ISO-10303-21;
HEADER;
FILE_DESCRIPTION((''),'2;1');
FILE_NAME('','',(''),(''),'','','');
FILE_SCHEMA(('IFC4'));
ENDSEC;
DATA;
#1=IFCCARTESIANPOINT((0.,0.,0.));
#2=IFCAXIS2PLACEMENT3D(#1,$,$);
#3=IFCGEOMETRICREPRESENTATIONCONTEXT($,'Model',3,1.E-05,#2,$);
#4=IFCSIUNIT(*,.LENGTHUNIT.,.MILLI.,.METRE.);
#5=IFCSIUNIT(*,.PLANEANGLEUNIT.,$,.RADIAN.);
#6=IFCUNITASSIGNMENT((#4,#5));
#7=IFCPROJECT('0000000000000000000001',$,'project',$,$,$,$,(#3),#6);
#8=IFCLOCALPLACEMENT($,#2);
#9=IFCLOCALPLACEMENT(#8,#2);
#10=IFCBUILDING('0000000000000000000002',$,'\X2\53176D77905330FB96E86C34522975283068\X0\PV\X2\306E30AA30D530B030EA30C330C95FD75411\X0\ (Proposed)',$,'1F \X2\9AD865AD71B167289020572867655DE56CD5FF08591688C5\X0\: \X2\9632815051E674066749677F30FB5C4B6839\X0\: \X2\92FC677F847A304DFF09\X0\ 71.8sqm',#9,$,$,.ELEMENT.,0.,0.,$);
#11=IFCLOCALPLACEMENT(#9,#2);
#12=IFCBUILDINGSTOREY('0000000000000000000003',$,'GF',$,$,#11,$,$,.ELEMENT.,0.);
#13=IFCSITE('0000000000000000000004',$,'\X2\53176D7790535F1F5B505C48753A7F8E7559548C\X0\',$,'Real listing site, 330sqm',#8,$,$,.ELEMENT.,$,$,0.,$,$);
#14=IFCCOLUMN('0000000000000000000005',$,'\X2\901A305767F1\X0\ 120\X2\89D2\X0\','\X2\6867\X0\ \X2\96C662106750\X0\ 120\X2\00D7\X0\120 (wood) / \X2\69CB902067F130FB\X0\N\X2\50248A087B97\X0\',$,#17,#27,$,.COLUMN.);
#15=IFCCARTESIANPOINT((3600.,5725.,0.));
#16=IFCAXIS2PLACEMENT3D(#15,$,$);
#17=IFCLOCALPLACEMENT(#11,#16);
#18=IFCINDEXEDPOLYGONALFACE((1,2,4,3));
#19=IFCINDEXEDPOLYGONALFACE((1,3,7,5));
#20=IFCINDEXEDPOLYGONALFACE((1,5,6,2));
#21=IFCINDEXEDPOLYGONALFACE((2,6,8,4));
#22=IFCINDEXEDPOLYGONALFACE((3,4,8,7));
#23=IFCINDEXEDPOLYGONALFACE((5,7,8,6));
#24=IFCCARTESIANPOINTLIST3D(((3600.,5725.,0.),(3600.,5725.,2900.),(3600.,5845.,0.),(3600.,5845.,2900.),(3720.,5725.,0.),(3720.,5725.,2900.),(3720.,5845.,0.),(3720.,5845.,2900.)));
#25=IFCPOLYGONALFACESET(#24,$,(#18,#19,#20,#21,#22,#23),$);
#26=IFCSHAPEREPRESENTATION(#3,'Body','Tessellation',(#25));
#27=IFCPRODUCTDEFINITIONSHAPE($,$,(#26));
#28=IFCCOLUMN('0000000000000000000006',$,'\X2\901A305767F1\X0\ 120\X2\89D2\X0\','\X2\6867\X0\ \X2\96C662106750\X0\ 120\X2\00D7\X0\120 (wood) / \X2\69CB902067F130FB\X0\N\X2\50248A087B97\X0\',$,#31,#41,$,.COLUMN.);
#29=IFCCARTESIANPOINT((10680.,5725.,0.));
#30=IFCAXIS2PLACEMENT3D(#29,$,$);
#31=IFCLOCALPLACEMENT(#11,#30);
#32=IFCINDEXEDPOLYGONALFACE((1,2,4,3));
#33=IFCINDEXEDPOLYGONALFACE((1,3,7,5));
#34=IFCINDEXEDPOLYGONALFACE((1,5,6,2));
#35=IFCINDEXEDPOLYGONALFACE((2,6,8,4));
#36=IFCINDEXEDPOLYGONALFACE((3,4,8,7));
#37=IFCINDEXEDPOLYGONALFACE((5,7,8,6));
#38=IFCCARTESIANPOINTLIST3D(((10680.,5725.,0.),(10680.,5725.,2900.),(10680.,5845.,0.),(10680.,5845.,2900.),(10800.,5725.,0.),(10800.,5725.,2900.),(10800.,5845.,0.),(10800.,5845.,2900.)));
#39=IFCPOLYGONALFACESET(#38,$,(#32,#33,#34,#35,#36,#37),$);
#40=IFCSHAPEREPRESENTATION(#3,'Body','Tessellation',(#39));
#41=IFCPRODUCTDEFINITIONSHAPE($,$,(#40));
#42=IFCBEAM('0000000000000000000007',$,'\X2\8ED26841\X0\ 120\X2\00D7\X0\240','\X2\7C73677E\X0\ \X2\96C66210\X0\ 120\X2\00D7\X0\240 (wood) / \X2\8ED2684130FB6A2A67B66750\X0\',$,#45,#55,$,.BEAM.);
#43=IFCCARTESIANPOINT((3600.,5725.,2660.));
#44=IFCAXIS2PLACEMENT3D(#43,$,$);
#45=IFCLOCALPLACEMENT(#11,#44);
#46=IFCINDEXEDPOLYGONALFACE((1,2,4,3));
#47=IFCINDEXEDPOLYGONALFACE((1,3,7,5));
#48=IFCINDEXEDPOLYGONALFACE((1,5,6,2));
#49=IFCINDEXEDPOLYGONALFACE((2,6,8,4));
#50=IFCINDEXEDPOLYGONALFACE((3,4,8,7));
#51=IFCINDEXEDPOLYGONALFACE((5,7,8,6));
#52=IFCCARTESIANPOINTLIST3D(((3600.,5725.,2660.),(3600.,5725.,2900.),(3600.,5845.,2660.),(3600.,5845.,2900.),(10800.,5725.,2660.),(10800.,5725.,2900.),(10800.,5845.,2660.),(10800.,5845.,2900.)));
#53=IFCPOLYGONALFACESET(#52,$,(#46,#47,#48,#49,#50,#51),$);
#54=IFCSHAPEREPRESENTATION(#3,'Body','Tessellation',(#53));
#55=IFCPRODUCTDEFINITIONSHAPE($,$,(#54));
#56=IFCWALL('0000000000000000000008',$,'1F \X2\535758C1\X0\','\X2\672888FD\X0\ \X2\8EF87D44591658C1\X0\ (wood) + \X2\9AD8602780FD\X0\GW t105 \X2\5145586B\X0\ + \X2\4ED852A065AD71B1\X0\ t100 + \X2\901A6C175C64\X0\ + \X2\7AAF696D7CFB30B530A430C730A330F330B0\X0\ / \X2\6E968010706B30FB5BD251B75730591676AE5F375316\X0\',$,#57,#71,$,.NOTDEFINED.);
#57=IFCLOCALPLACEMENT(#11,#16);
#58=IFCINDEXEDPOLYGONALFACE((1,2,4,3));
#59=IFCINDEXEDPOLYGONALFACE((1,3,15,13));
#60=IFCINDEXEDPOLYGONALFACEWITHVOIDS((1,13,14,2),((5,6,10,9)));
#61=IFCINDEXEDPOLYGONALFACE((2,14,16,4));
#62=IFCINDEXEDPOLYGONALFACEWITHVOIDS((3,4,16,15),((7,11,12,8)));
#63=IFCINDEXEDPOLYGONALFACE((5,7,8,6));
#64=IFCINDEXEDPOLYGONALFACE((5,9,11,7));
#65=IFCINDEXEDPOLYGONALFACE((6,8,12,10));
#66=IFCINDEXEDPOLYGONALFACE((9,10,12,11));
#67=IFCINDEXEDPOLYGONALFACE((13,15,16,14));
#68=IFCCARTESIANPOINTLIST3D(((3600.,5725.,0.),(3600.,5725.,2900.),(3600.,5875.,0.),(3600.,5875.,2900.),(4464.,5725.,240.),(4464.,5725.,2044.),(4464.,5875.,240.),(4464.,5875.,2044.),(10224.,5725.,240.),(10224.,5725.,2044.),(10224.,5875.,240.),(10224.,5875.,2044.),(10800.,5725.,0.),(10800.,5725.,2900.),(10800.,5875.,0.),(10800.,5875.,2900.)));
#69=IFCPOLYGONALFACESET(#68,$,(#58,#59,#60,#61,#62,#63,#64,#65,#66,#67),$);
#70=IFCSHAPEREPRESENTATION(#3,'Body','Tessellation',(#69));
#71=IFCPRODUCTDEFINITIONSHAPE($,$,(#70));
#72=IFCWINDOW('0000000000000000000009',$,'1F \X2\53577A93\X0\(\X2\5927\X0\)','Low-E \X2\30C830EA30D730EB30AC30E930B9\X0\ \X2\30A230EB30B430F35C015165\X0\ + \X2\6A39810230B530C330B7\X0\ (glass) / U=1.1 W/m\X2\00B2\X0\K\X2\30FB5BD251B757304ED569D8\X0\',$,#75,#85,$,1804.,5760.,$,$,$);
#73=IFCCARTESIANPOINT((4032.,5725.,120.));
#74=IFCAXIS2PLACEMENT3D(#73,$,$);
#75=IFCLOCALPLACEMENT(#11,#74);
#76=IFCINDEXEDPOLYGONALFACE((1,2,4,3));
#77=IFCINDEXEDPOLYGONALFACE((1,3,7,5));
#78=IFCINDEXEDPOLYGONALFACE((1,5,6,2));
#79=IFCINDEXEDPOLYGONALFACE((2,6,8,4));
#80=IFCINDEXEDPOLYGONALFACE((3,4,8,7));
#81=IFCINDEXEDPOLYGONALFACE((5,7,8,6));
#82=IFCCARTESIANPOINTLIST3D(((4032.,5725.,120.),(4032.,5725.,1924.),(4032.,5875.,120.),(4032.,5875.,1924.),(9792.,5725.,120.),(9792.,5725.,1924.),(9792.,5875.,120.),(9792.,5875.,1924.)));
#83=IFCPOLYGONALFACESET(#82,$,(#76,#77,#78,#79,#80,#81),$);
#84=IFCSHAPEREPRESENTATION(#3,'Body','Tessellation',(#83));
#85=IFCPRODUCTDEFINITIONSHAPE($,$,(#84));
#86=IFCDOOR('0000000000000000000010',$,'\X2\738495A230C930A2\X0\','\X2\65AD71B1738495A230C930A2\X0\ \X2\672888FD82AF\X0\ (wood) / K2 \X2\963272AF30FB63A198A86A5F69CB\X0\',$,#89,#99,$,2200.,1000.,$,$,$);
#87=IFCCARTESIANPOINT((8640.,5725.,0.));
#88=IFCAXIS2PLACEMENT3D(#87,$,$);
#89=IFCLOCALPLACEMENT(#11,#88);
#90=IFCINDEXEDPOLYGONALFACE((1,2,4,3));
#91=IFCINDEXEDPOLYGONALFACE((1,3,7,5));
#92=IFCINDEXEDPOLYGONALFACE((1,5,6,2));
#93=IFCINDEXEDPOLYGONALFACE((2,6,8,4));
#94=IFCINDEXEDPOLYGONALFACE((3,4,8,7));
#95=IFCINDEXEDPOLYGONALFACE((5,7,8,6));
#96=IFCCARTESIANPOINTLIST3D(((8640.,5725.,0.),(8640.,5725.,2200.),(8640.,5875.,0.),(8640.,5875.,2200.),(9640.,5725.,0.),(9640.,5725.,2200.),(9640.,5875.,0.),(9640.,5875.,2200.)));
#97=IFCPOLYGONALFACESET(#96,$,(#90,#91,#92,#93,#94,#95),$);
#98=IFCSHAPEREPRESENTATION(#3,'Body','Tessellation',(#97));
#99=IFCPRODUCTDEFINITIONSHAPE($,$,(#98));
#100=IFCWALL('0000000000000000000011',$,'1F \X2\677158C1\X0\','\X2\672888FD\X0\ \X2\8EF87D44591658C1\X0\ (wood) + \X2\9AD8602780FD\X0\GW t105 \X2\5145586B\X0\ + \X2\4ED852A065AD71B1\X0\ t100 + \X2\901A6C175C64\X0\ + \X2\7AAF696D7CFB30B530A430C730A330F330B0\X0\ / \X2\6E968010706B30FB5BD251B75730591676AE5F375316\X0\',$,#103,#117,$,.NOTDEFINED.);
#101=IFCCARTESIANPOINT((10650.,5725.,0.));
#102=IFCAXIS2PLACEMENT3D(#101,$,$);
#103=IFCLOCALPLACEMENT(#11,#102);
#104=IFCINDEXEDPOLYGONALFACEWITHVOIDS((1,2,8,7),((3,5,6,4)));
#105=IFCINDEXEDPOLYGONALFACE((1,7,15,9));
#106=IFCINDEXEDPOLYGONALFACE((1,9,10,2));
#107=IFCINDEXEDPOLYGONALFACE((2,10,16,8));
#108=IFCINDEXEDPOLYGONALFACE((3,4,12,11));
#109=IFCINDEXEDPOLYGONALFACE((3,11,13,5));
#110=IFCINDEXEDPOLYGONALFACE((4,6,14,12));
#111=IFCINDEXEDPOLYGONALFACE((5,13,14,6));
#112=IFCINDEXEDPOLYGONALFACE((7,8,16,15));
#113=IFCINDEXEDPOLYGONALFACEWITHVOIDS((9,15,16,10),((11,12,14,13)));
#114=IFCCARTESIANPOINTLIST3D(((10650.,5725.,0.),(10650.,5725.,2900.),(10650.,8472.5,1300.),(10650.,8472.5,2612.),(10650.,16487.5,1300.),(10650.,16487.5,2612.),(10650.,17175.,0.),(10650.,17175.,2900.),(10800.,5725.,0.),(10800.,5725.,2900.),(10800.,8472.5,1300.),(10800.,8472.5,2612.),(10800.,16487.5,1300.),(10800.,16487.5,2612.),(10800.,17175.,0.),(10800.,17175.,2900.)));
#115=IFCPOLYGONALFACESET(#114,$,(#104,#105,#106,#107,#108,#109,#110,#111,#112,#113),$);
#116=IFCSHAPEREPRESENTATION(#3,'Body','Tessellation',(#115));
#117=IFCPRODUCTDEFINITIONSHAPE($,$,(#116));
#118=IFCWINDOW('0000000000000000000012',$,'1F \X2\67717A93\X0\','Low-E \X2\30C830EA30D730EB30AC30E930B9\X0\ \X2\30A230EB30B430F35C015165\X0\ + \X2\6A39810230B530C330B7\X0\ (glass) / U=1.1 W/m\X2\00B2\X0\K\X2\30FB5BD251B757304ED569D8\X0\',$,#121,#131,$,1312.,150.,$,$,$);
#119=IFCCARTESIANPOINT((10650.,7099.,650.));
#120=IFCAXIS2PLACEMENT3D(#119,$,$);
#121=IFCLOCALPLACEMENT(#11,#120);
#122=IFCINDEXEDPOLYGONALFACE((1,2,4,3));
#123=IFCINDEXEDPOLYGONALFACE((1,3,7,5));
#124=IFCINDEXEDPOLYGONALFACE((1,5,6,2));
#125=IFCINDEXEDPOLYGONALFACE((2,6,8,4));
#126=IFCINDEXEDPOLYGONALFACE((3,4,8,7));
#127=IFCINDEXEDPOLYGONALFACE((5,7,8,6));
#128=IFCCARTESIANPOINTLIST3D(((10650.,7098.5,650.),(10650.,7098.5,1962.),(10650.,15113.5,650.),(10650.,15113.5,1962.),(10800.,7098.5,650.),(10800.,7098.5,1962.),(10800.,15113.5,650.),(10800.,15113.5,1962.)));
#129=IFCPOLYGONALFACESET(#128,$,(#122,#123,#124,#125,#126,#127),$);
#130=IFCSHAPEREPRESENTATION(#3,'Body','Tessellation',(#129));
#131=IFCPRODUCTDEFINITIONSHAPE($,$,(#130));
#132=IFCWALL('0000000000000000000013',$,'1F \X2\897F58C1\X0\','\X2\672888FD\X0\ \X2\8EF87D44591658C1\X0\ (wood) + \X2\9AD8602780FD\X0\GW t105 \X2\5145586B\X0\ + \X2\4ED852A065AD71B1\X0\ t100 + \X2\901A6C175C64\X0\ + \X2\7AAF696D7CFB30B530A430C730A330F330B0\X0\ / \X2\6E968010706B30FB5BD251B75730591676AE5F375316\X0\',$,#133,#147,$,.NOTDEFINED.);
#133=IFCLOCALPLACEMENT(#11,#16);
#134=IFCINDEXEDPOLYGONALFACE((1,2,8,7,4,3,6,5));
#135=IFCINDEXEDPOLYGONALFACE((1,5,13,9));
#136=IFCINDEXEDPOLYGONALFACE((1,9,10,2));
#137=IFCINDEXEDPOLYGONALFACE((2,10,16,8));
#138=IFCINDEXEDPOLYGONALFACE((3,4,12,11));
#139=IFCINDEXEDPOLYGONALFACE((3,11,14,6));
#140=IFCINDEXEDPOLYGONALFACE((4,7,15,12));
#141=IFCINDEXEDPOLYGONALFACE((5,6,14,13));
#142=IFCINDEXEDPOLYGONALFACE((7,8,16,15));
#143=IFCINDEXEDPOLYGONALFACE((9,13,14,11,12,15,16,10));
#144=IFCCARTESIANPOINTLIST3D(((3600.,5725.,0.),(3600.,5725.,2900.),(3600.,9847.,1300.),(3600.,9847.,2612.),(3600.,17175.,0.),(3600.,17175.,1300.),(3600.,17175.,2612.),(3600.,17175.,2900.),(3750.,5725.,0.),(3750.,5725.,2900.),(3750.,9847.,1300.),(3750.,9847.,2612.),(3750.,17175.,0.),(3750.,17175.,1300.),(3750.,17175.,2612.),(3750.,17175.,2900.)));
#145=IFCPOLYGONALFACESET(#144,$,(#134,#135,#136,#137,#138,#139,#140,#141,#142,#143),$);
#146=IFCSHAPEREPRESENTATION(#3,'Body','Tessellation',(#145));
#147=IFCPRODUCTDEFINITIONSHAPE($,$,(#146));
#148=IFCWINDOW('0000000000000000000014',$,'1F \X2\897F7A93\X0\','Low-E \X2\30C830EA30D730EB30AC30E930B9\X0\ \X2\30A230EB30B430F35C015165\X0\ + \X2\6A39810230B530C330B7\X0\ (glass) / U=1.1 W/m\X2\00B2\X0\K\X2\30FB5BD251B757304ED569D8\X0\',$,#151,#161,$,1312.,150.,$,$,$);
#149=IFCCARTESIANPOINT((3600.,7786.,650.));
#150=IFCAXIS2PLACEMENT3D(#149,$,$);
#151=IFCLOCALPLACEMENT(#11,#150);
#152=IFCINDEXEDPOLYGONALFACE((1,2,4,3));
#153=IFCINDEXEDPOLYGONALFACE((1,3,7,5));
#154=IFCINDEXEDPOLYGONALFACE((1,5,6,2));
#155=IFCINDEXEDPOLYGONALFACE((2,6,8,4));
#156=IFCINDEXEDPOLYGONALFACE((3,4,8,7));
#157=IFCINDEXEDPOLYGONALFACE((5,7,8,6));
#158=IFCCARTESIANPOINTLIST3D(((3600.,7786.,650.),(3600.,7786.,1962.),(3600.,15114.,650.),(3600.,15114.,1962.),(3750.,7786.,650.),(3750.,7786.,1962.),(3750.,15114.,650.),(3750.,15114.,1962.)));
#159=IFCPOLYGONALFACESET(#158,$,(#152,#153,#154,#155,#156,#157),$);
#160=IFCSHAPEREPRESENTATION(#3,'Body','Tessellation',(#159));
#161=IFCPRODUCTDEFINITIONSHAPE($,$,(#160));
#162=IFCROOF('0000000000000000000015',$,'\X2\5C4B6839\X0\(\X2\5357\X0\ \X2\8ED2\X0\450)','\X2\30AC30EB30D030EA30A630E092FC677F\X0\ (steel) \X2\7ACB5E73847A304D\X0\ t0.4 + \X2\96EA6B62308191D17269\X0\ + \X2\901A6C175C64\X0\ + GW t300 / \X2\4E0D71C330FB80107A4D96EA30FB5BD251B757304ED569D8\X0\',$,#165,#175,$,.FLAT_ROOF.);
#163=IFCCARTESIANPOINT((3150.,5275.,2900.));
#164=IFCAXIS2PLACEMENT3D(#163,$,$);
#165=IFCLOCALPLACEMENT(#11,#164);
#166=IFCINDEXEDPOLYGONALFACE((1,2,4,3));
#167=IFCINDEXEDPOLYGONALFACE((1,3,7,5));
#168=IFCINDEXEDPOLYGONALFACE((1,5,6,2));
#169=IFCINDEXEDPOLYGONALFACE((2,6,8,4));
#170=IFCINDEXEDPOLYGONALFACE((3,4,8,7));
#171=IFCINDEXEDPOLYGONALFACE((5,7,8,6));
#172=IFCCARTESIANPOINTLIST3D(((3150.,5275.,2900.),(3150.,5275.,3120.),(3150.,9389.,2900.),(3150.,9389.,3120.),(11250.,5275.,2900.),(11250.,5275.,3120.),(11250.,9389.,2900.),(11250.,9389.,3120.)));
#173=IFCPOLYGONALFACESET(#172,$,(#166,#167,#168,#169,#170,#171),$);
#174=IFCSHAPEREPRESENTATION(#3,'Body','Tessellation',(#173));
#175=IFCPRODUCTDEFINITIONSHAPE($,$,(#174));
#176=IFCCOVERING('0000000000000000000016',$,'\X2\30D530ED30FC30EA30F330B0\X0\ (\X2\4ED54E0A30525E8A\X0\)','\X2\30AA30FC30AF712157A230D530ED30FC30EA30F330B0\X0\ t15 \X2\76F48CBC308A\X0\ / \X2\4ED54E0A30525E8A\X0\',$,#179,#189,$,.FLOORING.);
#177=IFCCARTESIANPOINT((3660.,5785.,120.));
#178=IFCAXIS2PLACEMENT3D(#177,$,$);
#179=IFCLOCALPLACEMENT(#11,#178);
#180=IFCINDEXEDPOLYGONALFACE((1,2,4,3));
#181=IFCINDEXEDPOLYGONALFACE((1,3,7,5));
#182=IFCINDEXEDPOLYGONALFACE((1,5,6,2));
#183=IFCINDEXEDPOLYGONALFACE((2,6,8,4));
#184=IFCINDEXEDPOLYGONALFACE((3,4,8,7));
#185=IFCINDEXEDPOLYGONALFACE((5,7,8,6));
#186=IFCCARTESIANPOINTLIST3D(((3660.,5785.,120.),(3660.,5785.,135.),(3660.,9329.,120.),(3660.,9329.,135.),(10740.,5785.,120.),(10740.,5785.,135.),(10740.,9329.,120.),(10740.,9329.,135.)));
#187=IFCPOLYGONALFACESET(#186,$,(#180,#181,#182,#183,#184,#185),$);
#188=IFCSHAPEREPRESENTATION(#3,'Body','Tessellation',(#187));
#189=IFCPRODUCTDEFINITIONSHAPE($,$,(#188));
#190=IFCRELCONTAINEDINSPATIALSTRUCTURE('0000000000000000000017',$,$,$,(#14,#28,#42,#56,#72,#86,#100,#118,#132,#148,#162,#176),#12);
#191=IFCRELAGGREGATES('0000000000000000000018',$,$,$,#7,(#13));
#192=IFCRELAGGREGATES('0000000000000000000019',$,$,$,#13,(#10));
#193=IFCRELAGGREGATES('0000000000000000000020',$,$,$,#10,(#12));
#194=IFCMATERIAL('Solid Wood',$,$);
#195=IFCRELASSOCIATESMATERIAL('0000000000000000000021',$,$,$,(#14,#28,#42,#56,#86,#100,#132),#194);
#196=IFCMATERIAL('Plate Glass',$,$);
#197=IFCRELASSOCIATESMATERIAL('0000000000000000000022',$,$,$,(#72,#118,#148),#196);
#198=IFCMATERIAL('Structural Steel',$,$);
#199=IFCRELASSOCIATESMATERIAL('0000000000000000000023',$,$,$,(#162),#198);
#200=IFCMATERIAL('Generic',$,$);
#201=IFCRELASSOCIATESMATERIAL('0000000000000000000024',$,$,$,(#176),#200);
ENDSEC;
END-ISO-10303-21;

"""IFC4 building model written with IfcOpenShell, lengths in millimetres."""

from ifc_helpers import new_model, si_unit, frame, frame_2d, origin, place, context, project, spatial, rectangle, extrude, material, element, fill, save


model = new_model("IFC4")

# Units and contexts
model_context = context("Model", 3, precision=1e-05, world=origin())
ifc_project = project(units=[si_unit("LENGTHUNIT", "METRE", prefix="MILLI"), si_unit("PLANEANGLEUNIT", "RADIAN")], contexts=[model_context])

# Site, building, storey
site_placement = place(None, origin())
site = spatial("IfcSite", under=ifc_project, at=site_placement, Name="北海道弟子屈町美留和", ObjectType="Real listing site, 330sqm", CompositionType="ELEMENT", RefElevation=0.0)
building_placement = place(site_placement, origin())
building = spatial("IfcBuilding", under=site, at=building_placement, Name="北海道・雨水利用とPVのオフグリッド志向 (Proposed)", ObjectType="1F 高断熱木造在来工法（外装: 防腐処理杉板・屋根: 鋼板葺き） 71.8sqm", CompositionType="ELEMENT", ElevationOfRefHeight=0.0, ElevationOfTerrain=0.0)
storey_placement = place(building_placement, origin())
storey = spatial("IfcBuildingStorey", under=building, at=storey_placement, Name="GF", CompositionType="ELEMENT", Elevation=0.0)

# Columns
ifc_material_1 = material(Name="Solid Wood")
column_1_placement = place(storey_placement, frame((3600.0, 5725.0, 0.0)))
element("IfcColumn", 1, at=column_1_placement, inside=storey, material=ifc_material_1, Name="通し柱 120角", Description="桧 集成材 120×120 (wood) / 構造柱・N値計算", PredefinedType="COLUMN", context=model_context, shape_type="SweptSolid", body=[
    extrude(rectangle(XDim=120.0, YDim=120.0, at=frame_2d((60.0, 60.0))), frame((3600.0, 5725.0, 0.0)), (0.0, 0.0, 1.0), 2900.0),
])
column_2_placement = place(storey_placement, frame((10680.0, 5725.0, 0.0)))
element("IfcColumn", 2, at=column_2_placement, inside=storey, material=ifc_material_1, Name="通し柱 120角", Description="桧 集成材 120×120 (wood) / 構造柱・N値計算", PredefinedType="COLUMN", context=model_context, shape_type="SweptSolid", body=[
    extrude(rectangle(XDim=120.0, YDim=120.0, at=frame_2d((60.0, 60.0))), frame((10680.0, 5725.0, 0.0)), (0.0, 0.0, 1.0), 2900.0),
])

# Beam
beam_1_placement = place(storey_placement, frame((3600.0, 5725.0, 2660.0)))
element("IfcBeam", 3, at=beam_1_placement, inside=storey, material=ifc_material_1, Name="軒桁 120×240", Description="米松 集成 120×240 (wood) / 軒桁・横架材", PredefinedType="BEAM", context=model_context, shape_type="SweptSolid", body=[
    extrude(rectangle(XDim=7200.0, YDim=120.0, at=frame_2d((3600.0, 60.0))), frame((3600.0, 5725.0, 2660.0)), (0.0, 0.0, 1.0), 240.0),
])

# Wall, openings, window, door
wall_1_placement = place(storey_placement, frame((3600.0, 5725.0, 0.0)))
wall_1 = element("IfcWall", 4, at=wall_1_placement, inside=storey, material=ifc_material_1, Name="1F 南壁", Description="木製 軸組外壁 (wood) + 高性能GW t105 充填 + 付加断熱 t100 + 通気層 + 窯業系サイディング / 準耐火・寒冷地外皮強化", PredefinedType="NOTDEFINED", context=model_context, shape_type="SweptSolid", body=[
    extrude(rectangle(XDim=7200.0, YDim=150.0, at=frame_2d((3600.0, 75.0))), frame((3600.0, 5725.0, 0.0)), (0.0, 0.0, 1.0), 2900.0),
])
opening_1_placement = place(storey_placement, frame((4032.0, 5725.0, 120.0)))
opening_1 = element("IfcOpeningElement", 5, at=opening_1_placement, cuts=wall_1, PredefinedType="NOTDEFINED", context=model_context, shape_type="SweptSolid", body=[
    extrude(rectangle(XDim=5760.0, YDim=150.0, at=frame_2d((2880.0, 75.0))), frame((4032.0, 5725.0, 120.0)), (0.0, 0.0, 1.0), 1804.0),
])
opening_2_placement = place(storey_placement, frame((8640.0, 5725.0, 0.0)))
opening_2 = element("IfcOpeningElement", 6, at=opening_2_placement, cuts=wall_1, PredefinedType="NOTDEFINED", context=model_context, shape_type="SweptSolid", body=[
    extrude(rectangle(XDim=1000.0, YDim=150.0, at=frame_2d((500.0, 75.0))), frame((8640.0, 5725.0, 0.0)), (0.0, 0.0, 1.0), 2200.0),
])
ifc_material_2 = material(Name="Plate Glass")
window_1_placement = place(storey_placement, frame((4032.0, 5725.0, 120.0)))
window_1 = element("IfcWindow", 7, at=window_1_placement, inside=storey, material=ifc_material_2, Name="1F 南窓(大)", Description="Low-E トリプルガラス アルゴン封入 + 樹脂サッシ (glass) / U=1.1 W/m²K・寒冷地仕様", OverallHeight=1804.0, OverallWidth=5760.0, context=model_context, shape_type="SweptSolid", body=[
    extrude(rectangle(XDim=5760.0, YDim=150.0, at=frame_2d((2880.0, 75.0))), frame((4032.0, 5725.0, 120.0)), (0.0, 0.0, 1.0), 1804.0),
])
fill(opening_1, window_1)
door_placement = place(storey_placement, frame((8640.0, 5725.0, 0.0)))
door = element("IfcDoor", 8, at=door_placement, inside=storey, material=ifc_material_1, Name="玄関ドア", Description="断熱玄関ドア 木製芯 (wood) / K2 防犯・採風機構", OverallHeight=2200.0, OverallWidth=1000.0, context=model_context, shape_type="SweptSolid", body=[
    extrude(rectangle(XDim=1000.0, YDim=150.0, at=frame_2d((500.0, 75.0))), frame((8640.0, 5725.0, 0.0)), (0.0, 0.0, 1.0), 2200.0),
])
fill(opening_2, door)

# Walls, openings, windows
wall_2_placement = place(storey_placement, frame((10650.0, 5725.0, 0.0)))
wall_2 = element("IfcWall", 9, at=wall_2_placement, inside=storey, material=ifc_material_1, Name="1F 東壁", Description="木製 軸組外壁 (wood) + 高性能GW t105 充填 + 付加断熱 t100 + 通気層 + 窯業系サイディング / 準耐火・寒冷地外皮強化", PredefinedType="NOTDEFINED", context=model_context, shape_type="SweptSolid", body=[
    extrude(rectangle(XDim=150.0, YDim=11450.0, at=frame_2d((75.0, 5725.0))), frame((10650.0, 5725.0, 0.0)), (0.0, 0.0, 1.0), 2900.0),
])
opening_3_placement = place(storey_placement, frame((10650.0, 7099.0, 650.0)))
opening_3 = element("IfcOpeningElement", 10, at=opening_3_placement, cuts=wall_2, PredefinedType="NOTDEFINED", context=model_context, shape_type="SweptSolid", body=[
    extrude(rectangle(XDim=150.0, YDim=8015.0, at=frame_2d((75.0, 4007.0))), frame((10650.0, 7099.0, 650.0)), (0.0, 0.0, 1.0), 1312.0),
])
window_2_placement = place(storey_placement, frame((10650.0, 7099.0, 650.0)))
window_2 = element("IfcWindow", 11, at=window_2_placement, inside=storey, material=ifc_material_2, Name="1F 東窓", Description="Low-E トリプルガラス アルゴン封入 + 樹脂サッシ (glass) / U=1.1 W/m²K・寒冷地仕様", OverallHeight=1312.0, OverallWidth=150.0, context=model_context, shape_type="SweptSolid", body=[
    extrude(rectangle(XDim=150.0, YDim=8015.0, at=frame_2d((75.0, 4007.0))), frame((10650.0, 7099.0, 650.0)), (0.0, 0.0, 1.0), 1312.0),
])
fill(opening_3, window_2)
wall_3_placement = place(storey_placement, frame((3600.0, 5725.0, 0.0)))
wall_3 = element("IfcWall", 12, at=wall_3_placement, inside=storey, material=ifc_material_1, Name="1F 西壁", Description="木製 軸組外壁 (wood) + 高性能GW t105 充填 + 付加断熱 t100 + 通気層 + 窯業系サイディング / 準耐火・寒冷地外皮強化", PredefinedType="NOTDEFINED", context=model_context, shape_type="SweptSolid", body=[
    extrude(rectangle(XDim=150.0, YDim=11450.0, at=frame_2d((75.0, 5725.0))), frame((3600.0, 5725.0, 0.0)), (0.0, 0.0, 1.0), 2900.0),
])
opening_4_placement = place(storey_placement, frame((3600.0, 7786.0, 650.0)))
opening_4 = element("IfcOpeningElement", 13, at=opening_4_placement, cuts=wall_3, PredefinedType="NOTDEFINED", context=model_context, shape_type="SweptSolid", body=[
    extrude(rectangle(XDim=150.0, YDim=7328.0, at=frame_2d((75.0, 3664.0))), frame((3600.0, 7786.0, 650.0)), (0.0, 0.0, 1.0), 1312.0),
])
window_3_placement = place(storey_placement, frame((3600.0, 7786.0, 650.0)))
window_3 = element("IfcWindow", 14, at=window_3_placement, inside=storey, material=ifc_material_2, Name="1F 西窓", Description="Low-E トリプルガラス アルゴン封入 + 樹脂サッシ (glass) / U=1.1 W/m²K・寒冷地仕様", OverallHeight=1312.0, OverallWidth=150.0, context=model_context, shape_type="SweptSolid", body=[
    extrude(rectangle(XDim=150.0, YDim=7328.0, at=frame_2d((75.0, 3664.0))), frame((3600.0, 7786.0, 650.0)), (0.0, 0.0, 1.0), 1312.0),
])
fill(opening_4, window_3)

# Roof
ifc_material_3 = material(Name="Structural Steel")
roof_placement = place(storey_placement, frame((3150.0, 5275.0, 2900.0)))
element("IfcRoof", 15, at=roof_placement, inside=storey, material=ifc_material_3, Name="屋根(南 軒450)", Description="ガルバリウム鋼板 (steel) 立平葺き t0.4 + 雪止め金物 + 通気層 + GW t300 / 不燃・耐積雪・寒冷地仕様", PredefinedType="FLAT_ROOF", context=model_context, shape_type="SweptSolid", body=[
    extrude(rectangle(XDim=8100.0, YDim=4114.0, at=frame_2d((4050.0, 2057.0))), frame((3150.0, 5275.0, 2900.0)), (0.0, 0.0, 1.0), 220.0),
])

# Covering
ifc_material_4 = material(Name="Generic")
covering_1_placement = place(storey_placement, frame((3660.0, 5785.0, 120.0)))
element("IfcCovering", 16, at=covering_1_placement, inside=storey, material=ifc_material_4, Name="フローリング (仕上げ床)", Description="オーク無垢フローリング t15 直貼り / 仕上げ床", PredefinedType="FLOORING", context=model_context, shape_type="SweptSolid", body=[
    extrude(rectangle(XDim=7080.0, YDim=3544.0, at=frame_2d((3540.0, 1772.0))), frame((3660.0, 5785.0, 120.0)), (0.0, 0.0, 1.0), 15.0),
])

save(model, "model.ifc")
